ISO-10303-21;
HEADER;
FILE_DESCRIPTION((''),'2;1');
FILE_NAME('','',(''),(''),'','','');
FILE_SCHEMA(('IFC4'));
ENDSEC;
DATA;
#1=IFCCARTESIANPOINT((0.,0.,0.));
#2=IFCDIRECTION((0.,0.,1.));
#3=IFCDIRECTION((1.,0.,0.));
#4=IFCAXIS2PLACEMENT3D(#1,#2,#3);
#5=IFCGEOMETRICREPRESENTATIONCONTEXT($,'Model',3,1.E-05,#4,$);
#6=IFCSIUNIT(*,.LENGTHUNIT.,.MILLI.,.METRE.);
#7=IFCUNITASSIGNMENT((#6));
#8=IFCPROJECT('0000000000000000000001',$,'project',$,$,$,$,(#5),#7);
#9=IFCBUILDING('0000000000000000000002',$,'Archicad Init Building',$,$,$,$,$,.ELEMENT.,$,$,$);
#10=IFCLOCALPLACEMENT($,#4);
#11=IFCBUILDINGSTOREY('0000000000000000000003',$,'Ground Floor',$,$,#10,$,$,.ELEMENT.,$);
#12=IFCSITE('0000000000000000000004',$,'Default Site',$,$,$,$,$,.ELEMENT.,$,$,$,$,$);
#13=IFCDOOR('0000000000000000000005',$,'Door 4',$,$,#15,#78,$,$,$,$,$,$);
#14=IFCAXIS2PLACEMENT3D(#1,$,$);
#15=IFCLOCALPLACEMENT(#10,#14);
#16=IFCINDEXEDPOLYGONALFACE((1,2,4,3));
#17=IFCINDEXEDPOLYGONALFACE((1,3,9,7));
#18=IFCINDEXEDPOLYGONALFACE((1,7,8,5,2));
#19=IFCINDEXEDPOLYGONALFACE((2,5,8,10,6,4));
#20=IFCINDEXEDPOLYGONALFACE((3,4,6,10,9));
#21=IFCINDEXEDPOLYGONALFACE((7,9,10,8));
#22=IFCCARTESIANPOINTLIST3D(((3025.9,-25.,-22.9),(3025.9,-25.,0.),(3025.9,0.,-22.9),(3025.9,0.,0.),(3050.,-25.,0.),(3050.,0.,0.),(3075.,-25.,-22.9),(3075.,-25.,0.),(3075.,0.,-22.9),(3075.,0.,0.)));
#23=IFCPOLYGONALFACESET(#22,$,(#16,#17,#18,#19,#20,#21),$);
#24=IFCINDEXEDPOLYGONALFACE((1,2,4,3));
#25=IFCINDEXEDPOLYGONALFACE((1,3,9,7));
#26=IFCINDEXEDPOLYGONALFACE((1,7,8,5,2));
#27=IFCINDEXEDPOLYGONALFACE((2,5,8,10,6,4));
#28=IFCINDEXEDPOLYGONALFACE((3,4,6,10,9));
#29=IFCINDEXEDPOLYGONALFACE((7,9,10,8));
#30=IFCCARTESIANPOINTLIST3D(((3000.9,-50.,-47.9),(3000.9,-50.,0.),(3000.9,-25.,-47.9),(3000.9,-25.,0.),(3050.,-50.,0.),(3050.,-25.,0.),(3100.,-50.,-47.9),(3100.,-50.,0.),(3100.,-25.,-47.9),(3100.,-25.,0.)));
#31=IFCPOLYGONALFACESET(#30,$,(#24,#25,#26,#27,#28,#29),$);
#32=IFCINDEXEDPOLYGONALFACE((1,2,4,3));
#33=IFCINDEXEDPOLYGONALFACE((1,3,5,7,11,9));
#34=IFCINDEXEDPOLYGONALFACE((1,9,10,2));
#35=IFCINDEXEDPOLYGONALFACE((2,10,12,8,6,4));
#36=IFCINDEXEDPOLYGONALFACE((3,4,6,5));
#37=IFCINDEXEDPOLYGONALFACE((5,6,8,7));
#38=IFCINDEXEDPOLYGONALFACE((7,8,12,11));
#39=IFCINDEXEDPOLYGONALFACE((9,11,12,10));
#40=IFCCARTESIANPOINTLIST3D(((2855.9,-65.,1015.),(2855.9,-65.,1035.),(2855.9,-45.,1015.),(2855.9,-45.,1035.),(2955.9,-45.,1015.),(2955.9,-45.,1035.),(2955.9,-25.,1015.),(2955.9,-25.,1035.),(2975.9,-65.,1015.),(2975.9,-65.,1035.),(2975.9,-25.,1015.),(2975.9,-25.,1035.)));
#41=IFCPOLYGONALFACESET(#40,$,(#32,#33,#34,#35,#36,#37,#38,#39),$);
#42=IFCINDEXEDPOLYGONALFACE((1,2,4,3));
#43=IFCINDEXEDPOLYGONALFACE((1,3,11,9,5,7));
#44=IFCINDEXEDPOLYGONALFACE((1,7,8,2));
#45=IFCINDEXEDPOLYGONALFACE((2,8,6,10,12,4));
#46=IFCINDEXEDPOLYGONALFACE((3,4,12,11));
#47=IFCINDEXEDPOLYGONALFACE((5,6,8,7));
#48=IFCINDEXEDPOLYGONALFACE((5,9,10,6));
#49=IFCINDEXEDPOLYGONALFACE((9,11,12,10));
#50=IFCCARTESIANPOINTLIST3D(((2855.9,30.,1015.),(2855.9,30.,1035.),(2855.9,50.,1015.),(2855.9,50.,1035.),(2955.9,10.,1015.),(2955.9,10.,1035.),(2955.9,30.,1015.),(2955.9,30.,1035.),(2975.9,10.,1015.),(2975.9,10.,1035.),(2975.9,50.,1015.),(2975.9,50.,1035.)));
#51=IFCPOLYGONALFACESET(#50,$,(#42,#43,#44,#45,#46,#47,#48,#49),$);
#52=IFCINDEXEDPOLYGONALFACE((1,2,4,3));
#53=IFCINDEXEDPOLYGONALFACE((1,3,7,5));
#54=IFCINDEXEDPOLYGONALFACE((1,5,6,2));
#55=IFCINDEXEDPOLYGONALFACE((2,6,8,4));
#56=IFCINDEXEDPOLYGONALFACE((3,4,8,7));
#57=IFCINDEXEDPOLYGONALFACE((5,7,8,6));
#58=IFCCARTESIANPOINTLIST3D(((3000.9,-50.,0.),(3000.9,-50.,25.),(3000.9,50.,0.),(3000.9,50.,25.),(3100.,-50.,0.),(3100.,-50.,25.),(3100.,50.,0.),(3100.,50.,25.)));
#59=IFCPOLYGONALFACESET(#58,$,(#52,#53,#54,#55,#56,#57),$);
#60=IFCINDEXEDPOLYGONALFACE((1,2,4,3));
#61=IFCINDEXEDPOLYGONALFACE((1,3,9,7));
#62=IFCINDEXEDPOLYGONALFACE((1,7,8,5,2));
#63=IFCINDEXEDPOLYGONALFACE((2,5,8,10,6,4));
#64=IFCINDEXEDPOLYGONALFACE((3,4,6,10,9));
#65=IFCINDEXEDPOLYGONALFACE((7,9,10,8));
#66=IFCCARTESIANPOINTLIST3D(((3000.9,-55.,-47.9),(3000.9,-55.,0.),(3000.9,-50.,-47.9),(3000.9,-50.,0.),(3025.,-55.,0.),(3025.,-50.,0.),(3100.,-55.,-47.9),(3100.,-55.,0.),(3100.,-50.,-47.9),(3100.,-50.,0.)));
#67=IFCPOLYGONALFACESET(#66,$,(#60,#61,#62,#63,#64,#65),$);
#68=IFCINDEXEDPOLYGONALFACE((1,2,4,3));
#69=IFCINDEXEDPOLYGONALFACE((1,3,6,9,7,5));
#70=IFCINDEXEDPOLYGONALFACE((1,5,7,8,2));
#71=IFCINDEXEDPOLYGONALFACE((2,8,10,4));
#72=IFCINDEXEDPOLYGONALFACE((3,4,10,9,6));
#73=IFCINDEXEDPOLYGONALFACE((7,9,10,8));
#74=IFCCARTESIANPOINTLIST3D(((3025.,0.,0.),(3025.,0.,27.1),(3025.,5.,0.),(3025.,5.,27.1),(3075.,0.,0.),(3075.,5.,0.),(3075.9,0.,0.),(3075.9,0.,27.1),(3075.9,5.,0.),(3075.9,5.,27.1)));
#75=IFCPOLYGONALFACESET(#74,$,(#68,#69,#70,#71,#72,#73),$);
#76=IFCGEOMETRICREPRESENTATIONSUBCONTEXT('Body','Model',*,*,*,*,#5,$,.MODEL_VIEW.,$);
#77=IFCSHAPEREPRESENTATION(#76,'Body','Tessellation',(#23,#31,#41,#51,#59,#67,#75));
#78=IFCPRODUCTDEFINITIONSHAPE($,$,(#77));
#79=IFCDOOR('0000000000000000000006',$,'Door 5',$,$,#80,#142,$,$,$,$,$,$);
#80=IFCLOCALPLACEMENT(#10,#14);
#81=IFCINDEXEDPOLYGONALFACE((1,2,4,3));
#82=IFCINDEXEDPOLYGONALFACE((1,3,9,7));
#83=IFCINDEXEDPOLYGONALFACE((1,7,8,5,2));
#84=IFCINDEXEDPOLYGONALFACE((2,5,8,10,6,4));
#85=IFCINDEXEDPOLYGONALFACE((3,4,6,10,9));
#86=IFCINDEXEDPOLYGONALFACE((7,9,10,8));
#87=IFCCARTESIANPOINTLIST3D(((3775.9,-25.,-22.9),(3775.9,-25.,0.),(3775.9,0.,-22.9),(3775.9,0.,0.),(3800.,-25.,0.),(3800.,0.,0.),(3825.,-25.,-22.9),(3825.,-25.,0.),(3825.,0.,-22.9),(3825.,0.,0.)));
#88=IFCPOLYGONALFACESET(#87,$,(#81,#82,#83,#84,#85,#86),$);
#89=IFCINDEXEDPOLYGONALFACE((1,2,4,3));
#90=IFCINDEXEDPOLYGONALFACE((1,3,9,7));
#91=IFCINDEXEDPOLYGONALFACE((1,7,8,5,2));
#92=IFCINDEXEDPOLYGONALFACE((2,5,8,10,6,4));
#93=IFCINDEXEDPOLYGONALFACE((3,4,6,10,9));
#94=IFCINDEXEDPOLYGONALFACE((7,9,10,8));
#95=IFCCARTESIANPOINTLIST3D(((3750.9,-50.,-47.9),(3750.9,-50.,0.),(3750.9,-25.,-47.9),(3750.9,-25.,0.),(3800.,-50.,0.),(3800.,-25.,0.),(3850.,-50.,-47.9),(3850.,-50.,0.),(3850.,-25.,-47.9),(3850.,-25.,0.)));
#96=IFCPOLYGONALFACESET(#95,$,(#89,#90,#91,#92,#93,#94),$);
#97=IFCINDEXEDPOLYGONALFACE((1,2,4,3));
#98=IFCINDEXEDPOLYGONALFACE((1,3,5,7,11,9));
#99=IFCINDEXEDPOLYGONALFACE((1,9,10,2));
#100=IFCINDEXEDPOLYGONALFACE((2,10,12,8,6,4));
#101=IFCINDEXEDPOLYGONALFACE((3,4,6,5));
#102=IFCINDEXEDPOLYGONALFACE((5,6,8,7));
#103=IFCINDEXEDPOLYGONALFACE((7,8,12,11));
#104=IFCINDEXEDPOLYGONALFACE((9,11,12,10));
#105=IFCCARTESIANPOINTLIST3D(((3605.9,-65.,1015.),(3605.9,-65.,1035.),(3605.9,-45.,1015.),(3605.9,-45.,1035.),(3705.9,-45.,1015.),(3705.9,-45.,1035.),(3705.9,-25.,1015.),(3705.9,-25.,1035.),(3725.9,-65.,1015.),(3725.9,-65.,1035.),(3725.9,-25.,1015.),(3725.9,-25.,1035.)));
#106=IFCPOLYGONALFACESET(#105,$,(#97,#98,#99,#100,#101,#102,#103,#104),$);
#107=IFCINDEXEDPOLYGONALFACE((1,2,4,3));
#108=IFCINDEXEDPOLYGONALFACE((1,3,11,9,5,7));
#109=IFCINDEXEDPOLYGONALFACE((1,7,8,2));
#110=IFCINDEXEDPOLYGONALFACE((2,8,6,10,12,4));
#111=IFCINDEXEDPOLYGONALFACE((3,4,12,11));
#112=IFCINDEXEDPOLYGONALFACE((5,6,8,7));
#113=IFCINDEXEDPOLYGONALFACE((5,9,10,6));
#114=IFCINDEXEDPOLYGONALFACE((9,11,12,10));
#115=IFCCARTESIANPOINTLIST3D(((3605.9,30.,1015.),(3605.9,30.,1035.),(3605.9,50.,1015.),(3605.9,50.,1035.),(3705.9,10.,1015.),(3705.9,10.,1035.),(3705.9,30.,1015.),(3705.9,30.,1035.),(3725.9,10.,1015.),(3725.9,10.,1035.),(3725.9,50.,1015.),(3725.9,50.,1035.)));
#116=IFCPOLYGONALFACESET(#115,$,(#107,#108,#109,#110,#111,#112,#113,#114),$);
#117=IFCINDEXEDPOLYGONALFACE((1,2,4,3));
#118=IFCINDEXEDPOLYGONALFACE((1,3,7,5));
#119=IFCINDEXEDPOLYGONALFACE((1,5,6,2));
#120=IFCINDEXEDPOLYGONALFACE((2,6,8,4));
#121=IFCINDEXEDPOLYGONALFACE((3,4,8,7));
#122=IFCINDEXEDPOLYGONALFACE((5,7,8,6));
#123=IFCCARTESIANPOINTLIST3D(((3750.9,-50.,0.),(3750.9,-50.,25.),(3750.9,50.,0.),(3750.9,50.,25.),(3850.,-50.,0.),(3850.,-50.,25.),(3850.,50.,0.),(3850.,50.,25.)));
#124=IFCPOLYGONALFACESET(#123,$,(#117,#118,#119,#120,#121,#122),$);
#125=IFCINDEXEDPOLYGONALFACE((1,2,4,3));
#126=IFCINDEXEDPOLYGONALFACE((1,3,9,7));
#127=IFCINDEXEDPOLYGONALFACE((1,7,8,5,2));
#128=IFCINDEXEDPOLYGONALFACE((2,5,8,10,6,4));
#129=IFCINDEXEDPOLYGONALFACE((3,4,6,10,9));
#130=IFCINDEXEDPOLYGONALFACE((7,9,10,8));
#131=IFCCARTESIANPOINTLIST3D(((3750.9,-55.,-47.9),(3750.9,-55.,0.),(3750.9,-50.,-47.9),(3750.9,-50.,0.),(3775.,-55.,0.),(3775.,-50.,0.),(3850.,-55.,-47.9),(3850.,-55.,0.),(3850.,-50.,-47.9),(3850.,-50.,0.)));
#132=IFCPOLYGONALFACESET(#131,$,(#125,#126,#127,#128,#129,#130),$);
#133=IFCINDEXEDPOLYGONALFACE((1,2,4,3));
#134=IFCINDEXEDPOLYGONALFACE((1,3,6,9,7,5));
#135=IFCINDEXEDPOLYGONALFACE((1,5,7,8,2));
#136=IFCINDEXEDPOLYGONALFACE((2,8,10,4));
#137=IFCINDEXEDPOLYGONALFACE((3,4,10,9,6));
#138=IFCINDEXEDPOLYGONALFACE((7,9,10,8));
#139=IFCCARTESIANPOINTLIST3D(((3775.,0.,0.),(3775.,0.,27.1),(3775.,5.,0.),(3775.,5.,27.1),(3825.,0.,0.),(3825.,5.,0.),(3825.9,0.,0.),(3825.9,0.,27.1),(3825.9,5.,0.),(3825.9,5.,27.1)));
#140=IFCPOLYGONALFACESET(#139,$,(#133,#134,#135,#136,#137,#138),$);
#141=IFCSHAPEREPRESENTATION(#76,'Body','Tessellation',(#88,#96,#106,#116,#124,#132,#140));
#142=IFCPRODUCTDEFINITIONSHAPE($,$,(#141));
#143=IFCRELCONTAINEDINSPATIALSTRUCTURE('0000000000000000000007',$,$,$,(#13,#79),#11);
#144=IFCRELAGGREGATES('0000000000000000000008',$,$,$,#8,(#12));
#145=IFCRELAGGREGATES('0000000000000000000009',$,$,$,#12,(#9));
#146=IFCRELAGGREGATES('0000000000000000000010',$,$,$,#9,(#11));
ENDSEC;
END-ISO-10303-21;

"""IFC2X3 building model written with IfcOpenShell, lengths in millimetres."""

from ifc_helpers import new_model, si_unit, frame, origin_with_axes, place, context, subcontext, project, spatial, polyline, outline, extrude, element, save


model = new_model("IFC2X3")

# Units and contexts
model_context = context("Model", 3, precision=1e-05, world=origin_with_axes())
body_context = subcontext(model_context, "Body", "Model", "MODEL_VIEW")
ifc_project = project(units=[si_unit("LENGTHUNIT", "METRE", prefix="MILLI")], contexts=[model_context])

# Site, building, storey
site = spatial("IfcSite", under=ifc_project, Name="Default Site", CompositionType="ELEMENT")
building = spatial("IfcBuilding", under=site, Name="Archicad Init Building", CompositionType="ELEMENT")
storey_placement = place(None, origin_with_axes())
storey = spatial("IfcBuildingStorey", under=building, at=storey_placement, Name="Ground Floor", CompositionType="ELEMENT")

# Doors
door_1_placement = place(storey_placement, frame((3050.0, -50.0, 0.0), z_axis=(0.0, 0.0, 1.0), x_axis=(1.0, 0.0, 0.0)))
element("IfcDoor", 1, at=door_1_placement, inside=storey, Name="Door 4", context=body_context, shape_type="SweptSolid", body=[
    extrude(outline(polyline([(0.0, 0.0), (0.0, 2.1), (0.9, 2.1), (0.9, 0.0), (-24.1, 0.0), (-24.1, -22.9), (25.0, -22.9), (25.0, 0.0), (0.0, 0.0)])), frame((0.0, 25.0, 0.0), z_axis=(0.0, -1.0, 0.0), x_axis=(1.0, 0.0, 0.0)), (0.0, 0.0, -1.0), 25.0),
    extrude(outline(polyline([(0.0, 0.0), (0.0, 2.1), (0.9, 2.1), (0.9, 0.0), (-49.1, 0.0), (-49.1, -47.9), (50.0, -47.9), (50.0, 0.0), (0.0, 0.0)])), frame((0.0, 0.0, 0.0), z_axis=(0.0, -1.0, 0.0), x_axis=(1.0, 0.0, 0.0)), (0.0, 0.0, -1.0), 25.0),
    extrude(outline(polyline([(0.0, 0.0), (-49.1, 0.0), (-49.1, 35.0), (0.0, 35.0), (0.0, 0.0)])), frame((25.0, 25.0, 25.0), z_axis=(0.0, 0.0, 1.0), x_axis=(1.0, 0.0, 0.0)), (0.0, 0.0, 1.0), -47.9),
    extrude(outline(polyline([(0.0, 0.0), (0.0, -40.0), (-120.0, -40.0), (-120.0, -20.0), (-20.0, -20.0), (-20.0, 0.0), (0.0, 0.0)])), frame((-74.1, 25.0, 1015.0), z_axis=(0.0, 0.0, 1.0), x_axis=(1.0, 0.0, 0.0)), (0.0, 0.0, 1.0), 20.0),
    extrude(outline(polyline([(0.0, 0.0), (0.0, 40.0), (-120.0, 40.0), (-120.0, 20.0), (-20.0, 20.0), (-20.0, 0.0), (0.0, 0.0)])), frame((-74.1, 60.0, 1015.0), z_axis=(0.0, 0.0, 1.0), x_axis=(1.0, 0.0, 0.0)), (0.0, 0.0, 1.0), 20.0),
    extrude(outline(polyline([(0.0, 0.0), (-99.1, 0.0), (-99.1, 100.0), (0.0, 100.0), (0.0, 0.0)])), frame((50.0, 0.0, 0.0), z_axis=(0.0, 0.0, 1.0), x_axis=(1.0, 0.0, 0.0)), (0.0, 0.0, 1.0), 25.0),
    extrude(outline(polyline([(0.0, 0.0), (0.0, 27.1), (50.9, 27.1), (50.9, 0.0), (-24.1, 0.0), (-24.1, -47.9), (75.0, -47.9), (75.0, 0.0), (0.0, 0.0)])), frame((-25.0, -5.0, 0.0), z_axis=(0.0, -1.0, 0.0), x_axis=(1.0, 0.0, 0.0)), (0.0, 0.0, -1.0), 5.0),
    extrude(outline(polyline([(0.0, 0.0), (0.0, 27.1), (50.9, 27.1), (50.9, 0.0), (0.9, 0.0), (0.9, -22.9), (50.0, -22.9), (50.0, 0.0), (0.0, 0.0)])), frame((-25.0, 50.0, 0.0), z_axis=(0.0, -1.0, 0.0), x_axis=(1.0, 0.0, 0.0)), (0.0, 0.0, -1.0), 5.0),
])
door_2_placement = place(storey_placement, frame((3800.0, -50.0, 0.0), z_axis=(0.0, 0.0, 1.0), x_axis=(1.0, 0.0, 0.0)))
element("IfcDoor", 2, at=door_2_placement, inside=storey, Name="Door 5", context=body_context, shape_type="SweptSolid", body=[
    extrude(outline(polyline([(0.0, 0.0), (0.0, 2.1), (0.9, 2.1), (0.9, 0.0), (-24.1, 0.0), (-24.1, -22.9), (25.0, -22.9), (25.0, 0.0), (0.0, 0.0)])), frame((0.0, 25.0, 0.0), z_axis=(0.0, -1.0, 0.0), x_axis=(1.0, 0.0, 0.0)), (0.0, 0.0, -1.0), 25.0),
    extrude(outline(polyline([(0.0, 0.0), (0.0, 2.1), (0.9, 2.1), (0.9, 0.0), (-49.1, 0.0), (-49.1, -47.9), (50.0, -47.9), (50.0, 0.0), (0.0, 0.0)])), frame((0.0, 0.0, 0.0), z_axis=(0.0, -1.0, 0.0), x_axis=(1.0, 0.0, 0.0)), (0.0, 0.0, -1.0), 25.0),
    extrude(outline(polyline([(0.0, 0.0), (-49.1, 0.0), (-49.1, 35.0), (0.0, 35.0), (0.0, 0.0)])), frame((25.0, 25.0, 25.0), z_axis=(0.0, 0.0, 1.0), x_axis=(1.0, 0.0, 0.0)), (0.0, 0.0, 1.0), -47.9),
    extrude(outline(polyline([(0.0, 0.0), (0.0, -40.0), (-120.0, -40.0), (-120.0, -20.0), (-20.0, -20.0), (-20.0, 0.0), (0.0, 0.0)])), frame((-74.1, 25.0, 1015.0), z_axis=(0.0, 0.0, 1.0), x_axis=(1.0, 0.0, 0.0)), (0.0, 0.0, 1.0), 20.0),
    extrude(outline(polyline([(0.0, 0.0), (0.0, 40.0), (-120.0, 40.0), (-120.0, 20.0), (-20.0, 20.0), (-20.0, 0.0), (0.0, 0.0)])), frame((-74.1, 60.0, 1015.0), z_axis=(0.0, 0.0, 1.0), x_axis=(1.0, 0.0, 0.0)), (0.0, 0.0, 1.0), 20.0),
    extrude(outline(polyline([(0.0, 0.0), (-99.1, 0.0), (-99.1, 100.0), (0.0, 100.0), (0.0, 0.0)])), frame((50.0, 0.0, 0.0), z_axis=(0.0, 0.0, 1.0), x_axis=(1.0, 0.0, 0.0)), (0.0, 0.0, 1.0), 25.0),
    extrude(outline(polyline([(0.0, 0.0), (0.0, 27.1), (50.9, 27.1), (50.9, 0.0), (-24.1, 0.0), (-24.1, -47.9), (75.0, -47.9), (75.0, 0.0), (0.0, 0.0)])), frame((-25.0, -5.0, 0.0), z_axis=(0.0, -1.0, 0.0), x_axis=(1.0, 0.0, 0.0)), (0.0, 0.0, -1.0), 5.0),
    extrude(outline(polyline([(0.0, 0.0), (0.0, 27.1), (50.9, 27.1), (50.9, 0.0), (0.9, 0.0), (0.9, -22.9), (50.0, -22.9), (50.0, 0.0), (0.0, 0.0)])), frame((-25.0, 50.0, 0.0), z_axis=(0.0, -1.0, 0.0), x_axis=(1.0, 0.0, 0.0)), (0.0, 0.0, -1.0), 5.0),
])

save(model, "model.ifc")
